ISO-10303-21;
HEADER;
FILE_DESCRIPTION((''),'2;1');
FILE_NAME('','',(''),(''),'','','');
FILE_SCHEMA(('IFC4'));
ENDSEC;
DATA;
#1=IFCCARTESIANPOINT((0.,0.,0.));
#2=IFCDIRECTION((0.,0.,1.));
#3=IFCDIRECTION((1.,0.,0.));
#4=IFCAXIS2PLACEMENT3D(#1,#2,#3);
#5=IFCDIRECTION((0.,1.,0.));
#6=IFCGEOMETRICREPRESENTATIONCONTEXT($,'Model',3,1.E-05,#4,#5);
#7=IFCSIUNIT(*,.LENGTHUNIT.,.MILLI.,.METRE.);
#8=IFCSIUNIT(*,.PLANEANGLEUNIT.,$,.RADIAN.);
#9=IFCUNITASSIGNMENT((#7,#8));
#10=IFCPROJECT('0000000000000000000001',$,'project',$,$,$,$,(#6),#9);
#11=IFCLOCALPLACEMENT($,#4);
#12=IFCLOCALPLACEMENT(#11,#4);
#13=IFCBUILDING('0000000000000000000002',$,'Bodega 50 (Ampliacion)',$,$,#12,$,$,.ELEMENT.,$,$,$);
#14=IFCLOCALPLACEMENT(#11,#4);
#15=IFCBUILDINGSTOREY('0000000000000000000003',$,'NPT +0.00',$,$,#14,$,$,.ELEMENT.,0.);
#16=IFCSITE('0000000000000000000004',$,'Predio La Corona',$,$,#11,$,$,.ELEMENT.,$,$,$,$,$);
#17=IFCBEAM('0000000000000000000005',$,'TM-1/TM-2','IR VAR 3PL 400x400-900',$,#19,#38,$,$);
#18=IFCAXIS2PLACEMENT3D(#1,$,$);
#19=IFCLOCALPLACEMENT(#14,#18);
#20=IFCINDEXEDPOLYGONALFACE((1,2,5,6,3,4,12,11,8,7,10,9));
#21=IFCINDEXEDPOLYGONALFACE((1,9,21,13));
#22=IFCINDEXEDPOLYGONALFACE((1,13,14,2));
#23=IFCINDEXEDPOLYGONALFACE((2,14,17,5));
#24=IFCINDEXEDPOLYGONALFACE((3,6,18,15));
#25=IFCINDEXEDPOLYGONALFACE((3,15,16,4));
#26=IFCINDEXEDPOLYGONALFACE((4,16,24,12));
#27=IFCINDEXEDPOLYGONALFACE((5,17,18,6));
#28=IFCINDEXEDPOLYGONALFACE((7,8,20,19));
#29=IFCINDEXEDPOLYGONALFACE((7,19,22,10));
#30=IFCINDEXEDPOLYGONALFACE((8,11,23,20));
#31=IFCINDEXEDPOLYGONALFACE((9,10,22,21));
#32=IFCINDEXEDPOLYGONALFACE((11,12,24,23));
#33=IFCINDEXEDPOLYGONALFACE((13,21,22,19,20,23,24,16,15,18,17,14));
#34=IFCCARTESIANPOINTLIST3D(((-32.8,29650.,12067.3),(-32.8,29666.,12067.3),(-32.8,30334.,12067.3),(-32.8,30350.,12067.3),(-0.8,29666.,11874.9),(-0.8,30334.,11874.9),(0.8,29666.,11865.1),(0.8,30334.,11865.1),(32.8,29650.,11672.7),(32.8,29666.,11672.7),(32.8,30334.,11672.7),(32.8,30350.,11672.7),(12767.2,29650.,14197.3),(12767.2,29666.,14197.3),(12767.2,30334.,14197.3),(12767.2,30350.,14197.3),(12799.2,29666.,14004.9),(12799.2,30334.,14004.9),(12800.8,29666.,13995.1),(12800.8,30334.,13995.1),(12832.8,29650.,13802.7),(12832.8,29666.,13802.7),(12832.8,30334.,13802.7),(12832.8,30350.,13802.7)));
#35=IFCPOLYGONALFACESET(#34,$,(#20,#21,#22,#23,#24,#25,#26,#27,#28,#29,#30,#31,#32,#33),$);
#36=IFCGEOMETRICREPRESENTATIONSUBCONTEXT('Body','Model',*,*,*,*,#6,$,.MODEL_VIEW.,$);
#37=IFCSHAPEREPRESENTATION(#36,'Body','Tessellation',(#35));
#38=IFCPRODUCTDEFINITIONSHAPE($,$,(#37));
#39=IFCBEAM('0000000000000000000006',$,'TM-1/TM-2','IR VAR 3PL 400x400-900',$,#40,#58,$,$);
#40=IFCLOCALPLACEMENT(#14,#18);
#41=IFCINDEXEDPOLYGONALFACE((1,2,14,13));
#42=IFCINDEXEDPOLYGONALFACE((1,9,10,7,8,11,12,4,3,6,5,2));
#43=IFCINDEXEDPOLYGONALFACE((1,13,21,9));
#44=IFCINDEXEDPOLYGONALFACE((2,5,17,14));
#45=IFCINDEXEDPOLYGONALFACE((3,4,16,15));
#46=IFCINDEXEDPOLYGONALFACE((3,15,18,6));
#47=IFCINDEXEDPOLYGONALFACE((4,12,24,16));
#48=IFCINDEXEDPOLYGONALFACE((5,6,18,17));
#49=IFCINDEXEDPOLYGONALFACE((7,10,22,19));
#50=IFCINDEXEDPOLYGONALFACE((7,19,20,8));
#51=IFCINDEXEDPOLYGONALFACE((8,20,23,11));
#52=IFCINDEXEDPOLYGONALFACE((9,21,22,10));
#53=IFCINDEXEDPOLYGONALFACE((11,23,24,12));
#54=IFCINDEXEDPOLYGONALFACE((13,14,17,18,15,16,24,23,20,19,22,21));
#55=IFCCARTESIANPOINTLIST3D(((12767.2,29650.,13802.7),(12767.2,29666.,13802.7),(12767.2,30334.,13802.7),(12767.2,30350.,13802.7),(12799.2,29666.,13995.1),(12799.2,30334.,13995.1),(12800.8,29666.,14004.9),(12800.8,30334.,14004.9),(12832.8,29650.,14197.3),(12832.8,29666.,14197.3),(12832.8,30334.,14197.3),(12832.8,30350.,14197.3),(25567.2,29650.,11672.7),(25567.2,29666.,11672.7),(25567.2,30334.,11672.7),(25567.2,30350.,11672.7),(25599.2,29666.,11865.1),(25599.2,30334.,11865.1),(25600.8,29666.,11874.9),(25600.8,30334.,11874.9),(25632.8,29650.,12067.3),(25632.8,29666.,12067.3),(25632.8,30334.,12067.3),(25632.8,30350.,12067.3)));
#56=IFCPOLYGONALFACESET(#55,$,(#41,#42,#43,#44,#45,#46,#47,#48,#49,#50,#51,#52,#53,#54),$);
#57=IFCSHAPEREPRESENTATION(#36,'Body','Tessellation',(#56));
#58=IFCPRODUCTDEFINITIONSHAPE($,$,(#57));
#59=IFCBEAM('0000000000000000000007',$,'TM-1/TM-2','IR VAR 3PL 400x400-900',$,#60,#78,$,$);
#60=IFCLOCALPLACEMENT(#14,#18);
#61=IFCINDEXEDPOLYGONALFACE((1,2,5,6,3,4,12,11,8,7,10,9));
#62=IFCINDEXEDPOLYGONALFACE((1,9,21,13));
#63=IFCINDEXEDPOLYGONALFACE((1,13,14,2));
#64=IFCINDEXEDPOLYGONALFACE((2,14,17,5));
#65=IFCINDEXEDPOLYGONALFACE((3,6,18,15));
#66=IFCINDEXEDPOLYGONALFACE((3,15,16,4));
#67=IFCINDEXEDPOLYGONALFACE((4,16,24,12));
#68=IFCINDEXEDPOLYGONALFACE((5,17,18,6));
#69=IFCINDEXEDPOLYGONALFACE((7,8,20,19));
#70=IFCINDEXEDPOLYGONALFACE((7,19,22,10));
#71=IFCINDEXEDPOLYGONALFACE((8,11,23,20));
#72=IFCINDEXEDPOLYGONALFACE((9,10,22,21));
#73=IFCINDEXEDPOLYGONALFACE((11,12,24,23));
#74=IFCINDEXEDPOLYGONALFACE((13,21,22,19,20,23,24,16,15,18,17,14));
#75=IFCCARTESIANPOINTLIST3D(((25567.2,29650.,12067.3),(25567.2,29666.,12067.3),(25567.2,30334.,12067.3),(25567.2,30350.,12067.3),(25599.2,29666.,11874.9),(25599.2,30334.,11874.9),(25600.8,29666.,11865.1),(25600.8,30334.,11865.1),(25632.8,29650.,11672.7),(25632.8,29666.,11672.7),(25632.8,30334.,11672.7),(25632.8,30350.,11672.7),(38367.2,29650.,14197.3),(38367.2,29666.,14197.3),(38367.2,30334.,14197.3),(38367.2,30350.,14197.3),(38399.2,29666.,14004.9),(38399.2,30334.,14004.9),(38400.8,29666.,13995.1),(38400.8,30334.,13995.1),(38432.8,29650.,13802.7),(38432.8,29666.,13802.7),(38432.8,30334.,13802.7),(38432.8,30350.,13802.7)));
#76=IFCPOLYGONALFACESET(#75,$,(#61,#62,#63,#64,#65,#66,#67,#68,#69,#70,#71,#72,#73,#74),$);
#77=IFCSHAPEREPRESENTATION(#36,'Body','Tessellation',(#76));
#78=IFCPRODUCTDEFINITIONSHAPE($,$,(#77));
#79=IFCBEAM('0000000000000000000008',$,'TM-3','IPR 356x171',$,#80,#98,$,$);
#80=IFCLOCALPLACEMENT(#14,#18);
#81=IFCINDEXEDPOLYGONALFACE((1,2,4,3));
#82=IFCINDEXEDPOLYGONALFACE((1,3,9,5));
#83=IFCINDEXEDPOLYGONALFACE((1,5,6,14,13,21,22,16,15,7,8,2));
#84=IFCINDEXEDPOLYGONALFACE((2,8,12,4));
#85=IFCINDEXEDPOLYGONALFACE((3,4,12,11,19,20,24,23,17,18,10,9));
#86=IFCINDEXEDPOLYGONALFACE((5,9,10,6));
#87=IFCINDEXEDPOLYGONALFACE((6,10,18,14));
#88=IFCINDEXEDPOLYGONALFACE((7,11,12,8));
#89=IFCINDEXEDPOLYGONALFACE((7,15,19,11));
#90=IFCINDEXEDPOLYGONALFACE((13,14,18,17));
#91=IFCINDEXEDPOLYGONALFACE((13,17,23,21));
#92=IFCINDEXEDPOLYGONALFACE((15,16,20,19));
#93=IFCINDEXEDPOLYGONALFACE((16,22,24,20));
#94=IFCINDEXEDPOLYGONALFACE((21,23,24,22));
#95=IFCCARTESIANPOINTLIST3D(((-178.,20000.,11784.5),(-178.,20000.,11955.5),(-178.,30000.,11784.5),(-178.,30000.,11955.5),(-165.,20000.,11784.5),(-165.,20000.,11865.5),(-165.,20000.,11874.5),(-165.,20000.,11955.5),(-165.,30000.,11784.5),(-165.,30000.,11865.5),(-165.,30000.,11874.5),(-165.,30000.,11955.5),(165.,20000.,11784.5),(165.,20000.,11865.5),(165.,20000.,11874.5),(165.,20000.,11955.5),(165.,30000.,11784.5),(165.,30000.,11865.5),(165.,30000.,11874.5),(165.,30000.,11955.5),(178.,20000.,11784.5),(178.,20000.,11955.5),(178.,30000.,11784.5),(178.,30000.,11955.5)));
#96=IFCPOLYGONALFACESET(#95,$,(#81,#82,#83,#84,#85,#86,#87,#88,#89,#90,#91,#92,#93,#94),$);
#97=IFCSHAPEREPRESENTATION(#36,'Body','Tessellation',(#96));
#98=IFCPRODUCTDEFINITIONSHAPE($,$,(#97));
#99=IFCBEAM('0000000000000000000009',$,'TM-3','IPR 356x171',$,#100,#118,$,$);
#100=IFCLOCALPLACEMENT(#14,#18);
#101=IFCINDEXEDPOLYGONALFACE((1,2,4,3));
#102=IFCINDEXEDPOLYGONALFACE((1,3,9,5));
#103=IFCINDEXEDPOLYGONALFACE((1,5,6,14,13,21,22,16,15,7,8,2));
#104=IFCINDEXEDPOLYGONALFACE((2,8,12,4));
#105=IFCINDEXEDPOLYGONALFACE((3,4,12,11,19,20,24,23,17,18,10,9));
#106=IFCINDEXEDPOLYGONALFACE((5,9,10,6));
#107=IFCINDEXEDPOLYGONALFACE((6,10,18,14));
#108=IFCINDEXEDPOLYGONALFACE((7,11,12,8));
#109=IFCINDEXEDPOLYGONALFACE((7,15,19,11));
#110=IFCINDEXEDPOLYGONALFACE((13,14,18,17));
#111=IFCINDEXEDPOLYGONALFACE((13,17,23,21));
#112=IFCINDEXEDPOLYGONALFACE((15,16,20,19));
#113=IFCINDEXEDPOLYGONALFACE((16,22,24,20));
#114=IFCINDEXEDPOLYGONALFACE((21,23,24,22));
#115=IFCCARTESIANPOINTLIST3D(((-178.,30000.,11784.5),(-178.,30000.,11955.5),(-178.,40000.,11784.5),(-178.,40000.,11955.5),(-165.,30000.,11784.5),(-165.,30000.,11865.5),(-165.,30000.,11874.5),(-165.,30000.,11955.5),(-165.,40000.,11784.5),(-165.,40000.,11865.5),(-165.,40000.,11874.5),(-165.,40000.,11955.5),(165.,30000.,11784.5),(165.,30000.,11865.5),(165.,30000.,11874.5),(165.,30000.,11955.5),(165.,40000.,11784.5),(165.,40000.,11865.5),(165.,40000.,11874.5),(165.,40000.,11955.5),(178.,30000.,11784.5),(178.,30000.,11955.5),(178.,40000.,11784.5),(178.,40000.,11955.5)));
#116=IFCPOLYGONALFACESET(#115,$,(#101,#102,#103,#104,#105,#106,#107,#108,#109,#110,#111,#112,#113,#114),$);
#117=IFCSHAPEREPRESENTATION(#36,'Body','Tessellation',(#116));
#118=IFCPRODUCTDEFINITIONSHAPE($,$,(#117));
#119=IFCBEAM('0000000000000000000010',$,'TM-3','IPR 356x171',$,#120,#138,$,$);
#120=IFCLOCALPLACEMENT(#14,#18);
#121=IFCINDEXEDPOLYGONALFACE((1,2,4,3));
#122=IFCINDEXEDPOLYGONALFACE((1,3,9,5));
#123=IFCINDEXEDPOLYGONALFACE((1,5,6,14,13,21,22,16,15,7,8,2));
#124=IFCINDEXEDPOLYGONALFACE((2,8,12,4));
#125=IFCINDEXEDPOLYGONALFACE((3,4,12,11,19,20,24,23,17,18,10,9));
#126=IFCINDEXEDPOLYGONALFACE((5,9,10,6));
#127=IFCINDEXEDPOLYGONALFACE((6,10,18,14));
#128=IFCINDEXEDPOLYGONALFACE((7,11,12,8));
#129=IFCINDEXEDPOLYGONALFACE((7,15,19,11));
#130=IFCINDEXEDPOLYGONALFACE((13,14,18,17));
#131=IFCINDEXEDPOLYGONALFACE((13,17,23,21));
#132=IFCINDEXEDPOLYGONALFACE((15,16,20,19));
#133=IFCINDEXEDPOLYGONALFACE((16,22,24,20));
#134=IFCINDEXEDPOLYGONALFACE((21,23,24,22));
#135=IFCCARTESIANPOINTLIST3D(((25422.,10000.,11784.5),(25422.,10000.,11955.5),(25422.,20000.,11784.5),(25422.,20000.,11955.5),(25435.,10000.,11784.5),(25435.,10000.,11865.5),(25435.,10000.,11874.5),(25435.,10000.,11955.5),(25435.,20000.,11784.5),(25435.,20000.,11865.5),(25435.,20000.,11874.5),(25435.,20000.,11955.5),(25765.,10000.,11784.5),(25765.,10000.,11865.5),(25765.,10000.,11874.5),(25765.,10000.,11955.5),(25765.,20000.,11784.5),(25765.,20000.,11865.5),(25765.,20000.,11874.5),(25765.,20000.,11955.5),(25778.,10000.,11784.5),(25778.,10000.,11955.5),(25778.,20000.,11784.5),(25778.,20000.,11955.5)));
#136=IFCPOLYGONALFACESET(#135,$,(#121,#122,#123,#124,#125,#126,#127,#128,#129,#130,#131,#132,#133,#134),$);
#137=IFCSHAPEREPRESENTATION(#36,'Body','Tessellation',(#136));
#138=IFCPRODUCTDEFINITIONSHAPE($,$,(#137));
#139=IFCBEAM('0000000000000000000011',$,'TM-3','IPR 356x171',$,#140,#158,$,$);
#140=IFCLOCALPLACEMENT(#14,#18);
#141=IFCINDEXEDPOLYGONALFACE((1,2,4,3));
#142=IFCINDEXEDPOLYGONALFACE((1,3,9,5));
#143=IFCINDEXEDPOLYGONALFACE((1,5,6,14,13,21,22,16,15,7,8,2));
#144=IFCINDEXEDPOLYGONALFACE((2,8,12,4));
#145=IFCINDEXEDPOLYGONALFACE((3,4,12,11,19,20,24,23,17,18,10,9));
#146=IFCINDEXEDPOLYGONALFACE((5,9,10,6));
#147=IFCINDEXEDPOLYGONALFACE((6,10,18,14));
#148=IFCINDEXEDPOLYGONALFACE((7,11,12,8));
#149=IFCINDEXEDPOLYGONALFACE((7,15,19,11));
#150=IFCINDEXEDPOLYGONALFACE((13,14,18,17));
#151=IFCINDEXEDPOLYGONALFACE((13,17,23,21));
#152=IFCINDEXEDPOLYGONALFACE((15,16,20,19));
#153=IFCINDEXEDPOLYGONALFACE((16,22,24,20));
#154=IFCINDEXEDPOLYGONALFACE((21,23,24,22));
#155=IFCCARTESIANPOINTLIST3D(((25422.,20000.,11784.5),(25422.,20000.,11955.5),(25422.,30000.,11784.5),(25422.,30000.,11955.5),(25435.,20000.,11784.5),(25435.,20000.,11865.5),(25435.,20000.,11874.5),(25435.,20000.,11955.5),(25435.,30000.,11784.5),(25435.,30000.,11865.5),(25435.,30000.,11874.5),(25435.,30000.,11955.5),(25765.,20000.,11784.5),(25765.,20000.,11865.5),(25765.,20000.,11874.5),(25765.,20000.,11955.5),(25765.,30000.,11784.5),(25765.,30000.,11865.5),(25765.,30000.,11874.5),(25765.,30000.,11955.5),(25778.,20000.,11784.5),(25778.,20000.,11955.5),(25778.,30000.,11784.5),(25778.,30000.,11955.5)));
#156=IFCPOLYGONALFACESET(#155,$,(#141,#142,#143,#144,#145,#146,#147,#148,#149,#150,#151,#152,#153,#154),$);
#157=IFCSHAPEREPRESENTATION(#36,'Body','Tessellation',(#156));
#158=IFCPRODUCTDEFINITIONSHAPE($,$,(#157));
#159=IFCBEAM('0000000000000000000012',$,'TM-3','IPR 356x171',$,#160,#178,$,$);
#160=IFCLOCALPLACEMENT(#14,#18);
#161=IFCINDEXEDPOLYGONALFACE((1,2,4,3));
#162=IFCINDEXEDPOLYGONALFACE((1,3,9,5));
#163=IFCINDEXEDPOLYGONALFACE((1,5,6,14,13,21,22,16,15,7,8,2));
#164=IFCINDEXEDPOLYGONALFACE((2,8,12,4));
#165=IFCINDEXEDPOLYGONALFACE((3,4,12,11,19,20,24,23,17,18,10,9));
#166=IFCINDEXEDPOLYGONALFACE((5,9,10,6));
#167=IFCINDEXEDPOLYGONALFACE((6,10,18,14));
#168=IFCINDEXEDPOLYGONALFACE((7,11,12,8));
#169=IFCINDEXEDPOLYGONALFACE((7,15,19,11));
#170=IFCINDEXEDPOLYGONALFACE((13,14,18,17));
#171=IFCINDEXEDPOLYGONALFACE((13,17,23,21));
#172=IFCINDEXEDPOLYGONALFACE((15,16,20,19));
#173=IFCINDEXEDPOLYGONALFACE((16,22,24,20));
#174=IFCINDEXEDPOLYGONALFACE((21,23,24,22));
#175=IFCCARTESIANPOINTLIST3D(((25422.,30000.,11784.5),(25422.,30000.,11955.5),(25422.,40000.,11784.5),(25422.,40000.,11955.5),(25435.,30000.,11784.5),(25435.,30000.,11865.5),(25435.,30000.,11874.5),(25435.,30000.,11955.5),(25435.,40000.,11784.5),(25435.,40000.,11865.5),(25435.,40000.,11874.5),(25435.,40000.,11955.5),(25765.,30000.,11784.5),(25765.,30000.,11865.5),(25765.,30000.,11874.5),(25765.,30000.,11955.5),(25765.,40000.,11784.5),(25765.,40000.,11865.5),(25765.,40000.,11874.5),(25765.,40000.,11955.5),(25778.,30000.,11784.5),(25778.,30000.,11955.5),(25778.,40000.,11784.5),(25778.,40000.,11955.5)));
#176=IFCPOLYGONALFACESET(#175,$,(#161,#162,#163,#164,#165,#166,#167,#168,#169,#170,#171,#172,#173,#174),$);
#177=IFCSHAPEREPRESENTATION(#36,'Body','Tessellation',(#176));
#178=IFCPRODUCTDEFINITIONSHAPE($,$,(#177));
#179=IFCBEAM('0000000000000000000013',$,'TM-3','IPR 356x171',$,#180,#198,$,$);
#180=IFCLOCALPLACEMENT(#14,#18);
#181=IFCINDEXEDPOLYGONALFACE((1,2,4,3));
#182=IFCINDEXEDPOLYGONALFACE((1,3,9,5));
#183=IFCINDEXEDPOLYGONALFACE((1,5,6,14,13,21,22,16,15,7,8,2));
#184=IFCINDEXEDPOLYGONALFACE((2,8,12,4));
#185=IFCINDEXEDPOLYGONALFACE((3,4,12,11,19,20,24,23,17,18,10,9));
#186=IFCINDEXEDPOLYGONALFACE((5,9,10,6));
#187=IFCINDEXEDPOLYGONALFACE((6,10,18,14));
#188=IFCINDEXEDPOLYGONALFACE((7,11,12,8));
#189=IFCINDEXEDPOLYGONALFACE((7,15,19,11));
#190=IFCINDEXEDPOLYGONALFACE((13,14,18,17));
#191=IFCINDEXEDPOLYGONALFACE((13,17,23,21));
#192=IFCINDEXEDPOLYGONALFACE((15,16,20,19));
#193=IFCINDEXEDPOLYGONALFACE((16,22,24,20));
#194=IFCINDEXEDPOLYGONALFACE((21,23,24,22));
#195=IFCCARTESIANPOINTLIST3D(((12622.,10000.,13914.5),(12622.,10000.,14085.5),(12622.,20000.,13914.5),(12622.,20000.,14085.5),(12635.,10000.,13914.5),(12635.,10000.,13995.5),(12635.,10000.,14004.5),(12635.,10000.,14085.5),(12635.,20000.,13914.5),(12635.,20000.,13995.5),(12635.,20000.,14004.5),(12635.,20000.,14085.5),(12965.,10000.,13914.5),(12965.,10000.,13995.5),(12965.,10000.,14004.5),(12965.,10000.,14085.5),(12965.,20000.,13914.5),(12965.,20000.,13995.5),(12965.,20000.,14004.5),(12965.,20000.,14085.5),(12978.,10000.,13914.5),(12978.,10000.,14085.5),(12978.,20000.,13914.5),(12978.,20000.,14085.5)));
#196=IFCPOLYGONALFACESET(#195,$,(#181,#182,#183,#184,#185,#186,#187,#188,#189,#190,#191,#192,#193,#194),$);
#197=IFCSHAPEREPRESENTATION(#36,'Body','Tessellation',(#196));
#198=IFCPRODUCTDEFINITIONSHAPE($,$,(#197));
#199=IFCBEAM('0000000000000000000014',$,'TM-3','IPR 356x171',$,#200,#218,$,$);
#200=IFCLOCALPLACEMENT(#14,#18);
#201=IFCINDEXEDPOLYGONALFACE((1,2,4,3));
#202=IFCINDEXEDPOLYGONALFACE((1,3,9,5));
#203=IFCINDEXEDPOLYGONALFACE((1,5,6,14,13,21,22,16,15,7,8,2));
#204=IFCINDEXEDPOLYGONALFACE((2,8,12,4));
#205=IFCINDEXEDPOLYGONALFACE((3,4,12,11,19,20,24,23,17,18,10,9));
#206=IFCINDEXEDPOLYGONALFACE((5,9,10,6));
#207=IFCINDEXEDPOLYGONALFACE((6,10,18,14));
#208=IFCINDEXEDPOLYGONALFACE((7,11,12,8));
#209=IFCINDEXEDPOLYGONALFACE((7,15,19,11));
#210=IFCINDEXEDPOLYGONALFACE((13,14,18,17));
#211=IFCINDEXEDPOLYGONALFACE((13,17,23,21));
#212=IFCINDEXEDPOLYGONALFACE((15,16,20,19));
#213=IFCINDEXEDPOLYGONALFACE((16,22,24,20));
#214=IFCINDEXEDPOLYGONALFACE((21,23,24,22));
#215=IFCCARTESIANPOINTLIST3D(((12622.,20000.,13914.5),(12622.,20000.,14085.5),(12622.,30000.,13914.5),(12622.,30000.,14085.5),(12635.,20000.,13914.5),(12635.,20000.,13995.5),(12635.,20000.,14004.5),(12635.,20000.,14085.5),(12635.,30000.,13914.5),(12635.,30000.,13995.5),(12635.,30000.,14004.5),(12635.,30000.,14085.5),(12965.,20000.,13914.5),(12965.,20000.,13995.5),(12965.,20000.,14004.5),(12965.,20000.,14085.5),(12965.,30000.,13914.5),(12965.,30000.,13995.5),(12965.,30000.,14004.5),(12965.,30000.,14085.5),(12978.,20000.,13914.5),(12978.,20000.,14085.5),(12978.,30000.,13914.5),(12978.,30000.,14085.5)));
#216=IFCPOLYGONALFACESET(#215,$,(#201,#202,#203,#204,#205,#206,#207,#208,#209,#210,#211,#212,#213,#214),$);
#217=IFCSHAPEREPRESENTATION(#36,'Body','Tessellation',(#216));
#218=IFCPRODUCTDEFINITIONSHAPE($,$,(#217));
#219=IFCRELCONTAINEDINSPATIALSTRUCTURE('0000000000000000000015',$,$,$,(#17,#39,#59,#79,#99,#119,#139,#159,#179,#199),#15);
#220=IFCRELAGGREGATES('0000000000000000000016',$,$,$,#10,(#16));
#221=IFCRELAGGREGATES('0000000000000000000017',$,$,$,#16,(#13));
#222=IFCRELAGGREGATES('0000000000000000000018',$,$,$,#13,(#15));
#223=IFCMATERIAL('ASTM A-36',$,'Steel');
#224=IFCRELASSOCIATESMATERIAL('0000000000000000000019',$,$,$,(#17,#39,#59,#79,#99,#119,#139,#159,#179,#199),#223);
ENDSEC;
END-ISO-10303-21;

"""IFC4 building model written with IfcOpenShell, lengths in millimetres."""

from ifc_helpers import new_model, si_unit, direction, frame, origin_with_axes, origin_2d, place, context, subcontext, project, spatial, i_section, extrude, material, element, save


model = new_model("IFC4")

# Units and contexts
model_context = context("Model", 3, precision=1e-05, world=origin_with_axes(), true_north=direction((0.0, 1.0, 0.0)))
body_context = subcontext(model_context, "Body", "Model", "MODEL_VIEW")
ifc_project = project(units=[si_unit("LENGTHUNIT", "METRE", prefix="MILLI"), si_unit("PLANEANGLEUNIT", "RADIAN")], contexts=[model_context])

# Site, building, storey
site_placement = place(None, origin_with_axes())
site = spatial("IfcSite", under=ifc_project, at=site_placement, Name="Predio La Corona", CompositionType="ELEMENT")
building_placement = place(site_placement, origin_with_axes())
building = spatial("IfcBuilding", under=site, at=building_placement, Name="Bodega 50 (Ampliacion)", CompositionType="ELEMENT")
storey_placement = place(site_placement, origin_with_axes())
storey = spatial("IfcBuildingStorey", under=building, at=storey_placement, Name="NPT +0.00", CompositionType="ELEMENT", Elevation=0.0)

# Shared definitions
ifc_material = material(Name="ASTM A-36", Category="Steel")

# Beams
for number, where, z_axis, x_axis, name in (
    (1, (0.0, 30000.0, 11870.0), (0.986436, 0.0, 0.164149), (0.164149, 0.0, -0.986436), "TM-1/TM-2"),
    (2, (12800.0, 30000.0, 14000.0), (0.986436, 0.0, -0.164149), (-0.164149, 0.0, -0.986436), "TM-1/TM-2"),
    (3, (25600.0, 30000.0, 11870.0), (0.986436, 0.0, 0.164149), (0.164149, 0.0, -0.986436), "TM-1/TM-2"),
):
    element("IfcBeam", number, at=place(storey_placement, frame(where, z_axis=z_axis, x_axis=x_axis)), inside=storey, material=ifc_material, Name=name, Description="IR VAR 3PL 400x400-900", context=body_context, shape_type="SweptSolid", body=[
        extrude(i_section(OverallWidth=400.0, OverallDepth=700.0, WebThickness=10.0, FlangeThickness=16.0, at=origin_2d()), origin_with_axes(), (0.0, 0.0, 1.0), 12976.0),
    ])
for number, where, z_axis, x_axis, name in (
    (4, (0.0, 20000.0, 11870.0), (0.0, 1.0, 0.0), (0.0, 0.0, 1.0), "TM-3"),
    (5, (0.0, 30000.0, 11870.0), (0.0, 1.0, 0.0), (0.0, 0.0, 1.0), "TM-3"),
    (6, (25600.0, 10000.0, 11870.0), (0.0, 1.0, 0.0), (0.0, 0.0, 1.0), "TM-3"),
    (7, (25600.0, 20000.0, 11870.0), (0.0, 1.0, 0.0), (0.0, 0.0, 1.0), "TM-3"),
    (8, (25600.0, 30000.0, 11870.0), (0.0, 1.0, 0.0), (0.0, 0.0, 1.0), "TM-3"),
    (9, (12800.0, 10000.0, 14000.0), (0.0, 1.0, 0.0), (0.0, 0.0, 1.0), "TM-3"),
    (10, (12800.0, 20000.0, 14000.0), (0.0, 1.0, 0.0), (0.0, 0.0, 1.0), "TM-3"),
):
    element("IfcBeam", number, at=place(storey_placement, frame(where, z_axis=z_axis, x_axis=x_axis)), inside=storey, material=ifc_material, Name=name, Description="IPR 356x171", context=body_context, shape_type="SweptSolid", body=[
        extrude(i_section(OverallWidth=171.0, OverallDepth=356.0, WebThickness=9.0, FlangeThickness=13.0, at=origin_2d()), origin_with_axes(), (0.0, 0.0, 1.0), 10000.0),
    ])

save(model, "model.ifc")
